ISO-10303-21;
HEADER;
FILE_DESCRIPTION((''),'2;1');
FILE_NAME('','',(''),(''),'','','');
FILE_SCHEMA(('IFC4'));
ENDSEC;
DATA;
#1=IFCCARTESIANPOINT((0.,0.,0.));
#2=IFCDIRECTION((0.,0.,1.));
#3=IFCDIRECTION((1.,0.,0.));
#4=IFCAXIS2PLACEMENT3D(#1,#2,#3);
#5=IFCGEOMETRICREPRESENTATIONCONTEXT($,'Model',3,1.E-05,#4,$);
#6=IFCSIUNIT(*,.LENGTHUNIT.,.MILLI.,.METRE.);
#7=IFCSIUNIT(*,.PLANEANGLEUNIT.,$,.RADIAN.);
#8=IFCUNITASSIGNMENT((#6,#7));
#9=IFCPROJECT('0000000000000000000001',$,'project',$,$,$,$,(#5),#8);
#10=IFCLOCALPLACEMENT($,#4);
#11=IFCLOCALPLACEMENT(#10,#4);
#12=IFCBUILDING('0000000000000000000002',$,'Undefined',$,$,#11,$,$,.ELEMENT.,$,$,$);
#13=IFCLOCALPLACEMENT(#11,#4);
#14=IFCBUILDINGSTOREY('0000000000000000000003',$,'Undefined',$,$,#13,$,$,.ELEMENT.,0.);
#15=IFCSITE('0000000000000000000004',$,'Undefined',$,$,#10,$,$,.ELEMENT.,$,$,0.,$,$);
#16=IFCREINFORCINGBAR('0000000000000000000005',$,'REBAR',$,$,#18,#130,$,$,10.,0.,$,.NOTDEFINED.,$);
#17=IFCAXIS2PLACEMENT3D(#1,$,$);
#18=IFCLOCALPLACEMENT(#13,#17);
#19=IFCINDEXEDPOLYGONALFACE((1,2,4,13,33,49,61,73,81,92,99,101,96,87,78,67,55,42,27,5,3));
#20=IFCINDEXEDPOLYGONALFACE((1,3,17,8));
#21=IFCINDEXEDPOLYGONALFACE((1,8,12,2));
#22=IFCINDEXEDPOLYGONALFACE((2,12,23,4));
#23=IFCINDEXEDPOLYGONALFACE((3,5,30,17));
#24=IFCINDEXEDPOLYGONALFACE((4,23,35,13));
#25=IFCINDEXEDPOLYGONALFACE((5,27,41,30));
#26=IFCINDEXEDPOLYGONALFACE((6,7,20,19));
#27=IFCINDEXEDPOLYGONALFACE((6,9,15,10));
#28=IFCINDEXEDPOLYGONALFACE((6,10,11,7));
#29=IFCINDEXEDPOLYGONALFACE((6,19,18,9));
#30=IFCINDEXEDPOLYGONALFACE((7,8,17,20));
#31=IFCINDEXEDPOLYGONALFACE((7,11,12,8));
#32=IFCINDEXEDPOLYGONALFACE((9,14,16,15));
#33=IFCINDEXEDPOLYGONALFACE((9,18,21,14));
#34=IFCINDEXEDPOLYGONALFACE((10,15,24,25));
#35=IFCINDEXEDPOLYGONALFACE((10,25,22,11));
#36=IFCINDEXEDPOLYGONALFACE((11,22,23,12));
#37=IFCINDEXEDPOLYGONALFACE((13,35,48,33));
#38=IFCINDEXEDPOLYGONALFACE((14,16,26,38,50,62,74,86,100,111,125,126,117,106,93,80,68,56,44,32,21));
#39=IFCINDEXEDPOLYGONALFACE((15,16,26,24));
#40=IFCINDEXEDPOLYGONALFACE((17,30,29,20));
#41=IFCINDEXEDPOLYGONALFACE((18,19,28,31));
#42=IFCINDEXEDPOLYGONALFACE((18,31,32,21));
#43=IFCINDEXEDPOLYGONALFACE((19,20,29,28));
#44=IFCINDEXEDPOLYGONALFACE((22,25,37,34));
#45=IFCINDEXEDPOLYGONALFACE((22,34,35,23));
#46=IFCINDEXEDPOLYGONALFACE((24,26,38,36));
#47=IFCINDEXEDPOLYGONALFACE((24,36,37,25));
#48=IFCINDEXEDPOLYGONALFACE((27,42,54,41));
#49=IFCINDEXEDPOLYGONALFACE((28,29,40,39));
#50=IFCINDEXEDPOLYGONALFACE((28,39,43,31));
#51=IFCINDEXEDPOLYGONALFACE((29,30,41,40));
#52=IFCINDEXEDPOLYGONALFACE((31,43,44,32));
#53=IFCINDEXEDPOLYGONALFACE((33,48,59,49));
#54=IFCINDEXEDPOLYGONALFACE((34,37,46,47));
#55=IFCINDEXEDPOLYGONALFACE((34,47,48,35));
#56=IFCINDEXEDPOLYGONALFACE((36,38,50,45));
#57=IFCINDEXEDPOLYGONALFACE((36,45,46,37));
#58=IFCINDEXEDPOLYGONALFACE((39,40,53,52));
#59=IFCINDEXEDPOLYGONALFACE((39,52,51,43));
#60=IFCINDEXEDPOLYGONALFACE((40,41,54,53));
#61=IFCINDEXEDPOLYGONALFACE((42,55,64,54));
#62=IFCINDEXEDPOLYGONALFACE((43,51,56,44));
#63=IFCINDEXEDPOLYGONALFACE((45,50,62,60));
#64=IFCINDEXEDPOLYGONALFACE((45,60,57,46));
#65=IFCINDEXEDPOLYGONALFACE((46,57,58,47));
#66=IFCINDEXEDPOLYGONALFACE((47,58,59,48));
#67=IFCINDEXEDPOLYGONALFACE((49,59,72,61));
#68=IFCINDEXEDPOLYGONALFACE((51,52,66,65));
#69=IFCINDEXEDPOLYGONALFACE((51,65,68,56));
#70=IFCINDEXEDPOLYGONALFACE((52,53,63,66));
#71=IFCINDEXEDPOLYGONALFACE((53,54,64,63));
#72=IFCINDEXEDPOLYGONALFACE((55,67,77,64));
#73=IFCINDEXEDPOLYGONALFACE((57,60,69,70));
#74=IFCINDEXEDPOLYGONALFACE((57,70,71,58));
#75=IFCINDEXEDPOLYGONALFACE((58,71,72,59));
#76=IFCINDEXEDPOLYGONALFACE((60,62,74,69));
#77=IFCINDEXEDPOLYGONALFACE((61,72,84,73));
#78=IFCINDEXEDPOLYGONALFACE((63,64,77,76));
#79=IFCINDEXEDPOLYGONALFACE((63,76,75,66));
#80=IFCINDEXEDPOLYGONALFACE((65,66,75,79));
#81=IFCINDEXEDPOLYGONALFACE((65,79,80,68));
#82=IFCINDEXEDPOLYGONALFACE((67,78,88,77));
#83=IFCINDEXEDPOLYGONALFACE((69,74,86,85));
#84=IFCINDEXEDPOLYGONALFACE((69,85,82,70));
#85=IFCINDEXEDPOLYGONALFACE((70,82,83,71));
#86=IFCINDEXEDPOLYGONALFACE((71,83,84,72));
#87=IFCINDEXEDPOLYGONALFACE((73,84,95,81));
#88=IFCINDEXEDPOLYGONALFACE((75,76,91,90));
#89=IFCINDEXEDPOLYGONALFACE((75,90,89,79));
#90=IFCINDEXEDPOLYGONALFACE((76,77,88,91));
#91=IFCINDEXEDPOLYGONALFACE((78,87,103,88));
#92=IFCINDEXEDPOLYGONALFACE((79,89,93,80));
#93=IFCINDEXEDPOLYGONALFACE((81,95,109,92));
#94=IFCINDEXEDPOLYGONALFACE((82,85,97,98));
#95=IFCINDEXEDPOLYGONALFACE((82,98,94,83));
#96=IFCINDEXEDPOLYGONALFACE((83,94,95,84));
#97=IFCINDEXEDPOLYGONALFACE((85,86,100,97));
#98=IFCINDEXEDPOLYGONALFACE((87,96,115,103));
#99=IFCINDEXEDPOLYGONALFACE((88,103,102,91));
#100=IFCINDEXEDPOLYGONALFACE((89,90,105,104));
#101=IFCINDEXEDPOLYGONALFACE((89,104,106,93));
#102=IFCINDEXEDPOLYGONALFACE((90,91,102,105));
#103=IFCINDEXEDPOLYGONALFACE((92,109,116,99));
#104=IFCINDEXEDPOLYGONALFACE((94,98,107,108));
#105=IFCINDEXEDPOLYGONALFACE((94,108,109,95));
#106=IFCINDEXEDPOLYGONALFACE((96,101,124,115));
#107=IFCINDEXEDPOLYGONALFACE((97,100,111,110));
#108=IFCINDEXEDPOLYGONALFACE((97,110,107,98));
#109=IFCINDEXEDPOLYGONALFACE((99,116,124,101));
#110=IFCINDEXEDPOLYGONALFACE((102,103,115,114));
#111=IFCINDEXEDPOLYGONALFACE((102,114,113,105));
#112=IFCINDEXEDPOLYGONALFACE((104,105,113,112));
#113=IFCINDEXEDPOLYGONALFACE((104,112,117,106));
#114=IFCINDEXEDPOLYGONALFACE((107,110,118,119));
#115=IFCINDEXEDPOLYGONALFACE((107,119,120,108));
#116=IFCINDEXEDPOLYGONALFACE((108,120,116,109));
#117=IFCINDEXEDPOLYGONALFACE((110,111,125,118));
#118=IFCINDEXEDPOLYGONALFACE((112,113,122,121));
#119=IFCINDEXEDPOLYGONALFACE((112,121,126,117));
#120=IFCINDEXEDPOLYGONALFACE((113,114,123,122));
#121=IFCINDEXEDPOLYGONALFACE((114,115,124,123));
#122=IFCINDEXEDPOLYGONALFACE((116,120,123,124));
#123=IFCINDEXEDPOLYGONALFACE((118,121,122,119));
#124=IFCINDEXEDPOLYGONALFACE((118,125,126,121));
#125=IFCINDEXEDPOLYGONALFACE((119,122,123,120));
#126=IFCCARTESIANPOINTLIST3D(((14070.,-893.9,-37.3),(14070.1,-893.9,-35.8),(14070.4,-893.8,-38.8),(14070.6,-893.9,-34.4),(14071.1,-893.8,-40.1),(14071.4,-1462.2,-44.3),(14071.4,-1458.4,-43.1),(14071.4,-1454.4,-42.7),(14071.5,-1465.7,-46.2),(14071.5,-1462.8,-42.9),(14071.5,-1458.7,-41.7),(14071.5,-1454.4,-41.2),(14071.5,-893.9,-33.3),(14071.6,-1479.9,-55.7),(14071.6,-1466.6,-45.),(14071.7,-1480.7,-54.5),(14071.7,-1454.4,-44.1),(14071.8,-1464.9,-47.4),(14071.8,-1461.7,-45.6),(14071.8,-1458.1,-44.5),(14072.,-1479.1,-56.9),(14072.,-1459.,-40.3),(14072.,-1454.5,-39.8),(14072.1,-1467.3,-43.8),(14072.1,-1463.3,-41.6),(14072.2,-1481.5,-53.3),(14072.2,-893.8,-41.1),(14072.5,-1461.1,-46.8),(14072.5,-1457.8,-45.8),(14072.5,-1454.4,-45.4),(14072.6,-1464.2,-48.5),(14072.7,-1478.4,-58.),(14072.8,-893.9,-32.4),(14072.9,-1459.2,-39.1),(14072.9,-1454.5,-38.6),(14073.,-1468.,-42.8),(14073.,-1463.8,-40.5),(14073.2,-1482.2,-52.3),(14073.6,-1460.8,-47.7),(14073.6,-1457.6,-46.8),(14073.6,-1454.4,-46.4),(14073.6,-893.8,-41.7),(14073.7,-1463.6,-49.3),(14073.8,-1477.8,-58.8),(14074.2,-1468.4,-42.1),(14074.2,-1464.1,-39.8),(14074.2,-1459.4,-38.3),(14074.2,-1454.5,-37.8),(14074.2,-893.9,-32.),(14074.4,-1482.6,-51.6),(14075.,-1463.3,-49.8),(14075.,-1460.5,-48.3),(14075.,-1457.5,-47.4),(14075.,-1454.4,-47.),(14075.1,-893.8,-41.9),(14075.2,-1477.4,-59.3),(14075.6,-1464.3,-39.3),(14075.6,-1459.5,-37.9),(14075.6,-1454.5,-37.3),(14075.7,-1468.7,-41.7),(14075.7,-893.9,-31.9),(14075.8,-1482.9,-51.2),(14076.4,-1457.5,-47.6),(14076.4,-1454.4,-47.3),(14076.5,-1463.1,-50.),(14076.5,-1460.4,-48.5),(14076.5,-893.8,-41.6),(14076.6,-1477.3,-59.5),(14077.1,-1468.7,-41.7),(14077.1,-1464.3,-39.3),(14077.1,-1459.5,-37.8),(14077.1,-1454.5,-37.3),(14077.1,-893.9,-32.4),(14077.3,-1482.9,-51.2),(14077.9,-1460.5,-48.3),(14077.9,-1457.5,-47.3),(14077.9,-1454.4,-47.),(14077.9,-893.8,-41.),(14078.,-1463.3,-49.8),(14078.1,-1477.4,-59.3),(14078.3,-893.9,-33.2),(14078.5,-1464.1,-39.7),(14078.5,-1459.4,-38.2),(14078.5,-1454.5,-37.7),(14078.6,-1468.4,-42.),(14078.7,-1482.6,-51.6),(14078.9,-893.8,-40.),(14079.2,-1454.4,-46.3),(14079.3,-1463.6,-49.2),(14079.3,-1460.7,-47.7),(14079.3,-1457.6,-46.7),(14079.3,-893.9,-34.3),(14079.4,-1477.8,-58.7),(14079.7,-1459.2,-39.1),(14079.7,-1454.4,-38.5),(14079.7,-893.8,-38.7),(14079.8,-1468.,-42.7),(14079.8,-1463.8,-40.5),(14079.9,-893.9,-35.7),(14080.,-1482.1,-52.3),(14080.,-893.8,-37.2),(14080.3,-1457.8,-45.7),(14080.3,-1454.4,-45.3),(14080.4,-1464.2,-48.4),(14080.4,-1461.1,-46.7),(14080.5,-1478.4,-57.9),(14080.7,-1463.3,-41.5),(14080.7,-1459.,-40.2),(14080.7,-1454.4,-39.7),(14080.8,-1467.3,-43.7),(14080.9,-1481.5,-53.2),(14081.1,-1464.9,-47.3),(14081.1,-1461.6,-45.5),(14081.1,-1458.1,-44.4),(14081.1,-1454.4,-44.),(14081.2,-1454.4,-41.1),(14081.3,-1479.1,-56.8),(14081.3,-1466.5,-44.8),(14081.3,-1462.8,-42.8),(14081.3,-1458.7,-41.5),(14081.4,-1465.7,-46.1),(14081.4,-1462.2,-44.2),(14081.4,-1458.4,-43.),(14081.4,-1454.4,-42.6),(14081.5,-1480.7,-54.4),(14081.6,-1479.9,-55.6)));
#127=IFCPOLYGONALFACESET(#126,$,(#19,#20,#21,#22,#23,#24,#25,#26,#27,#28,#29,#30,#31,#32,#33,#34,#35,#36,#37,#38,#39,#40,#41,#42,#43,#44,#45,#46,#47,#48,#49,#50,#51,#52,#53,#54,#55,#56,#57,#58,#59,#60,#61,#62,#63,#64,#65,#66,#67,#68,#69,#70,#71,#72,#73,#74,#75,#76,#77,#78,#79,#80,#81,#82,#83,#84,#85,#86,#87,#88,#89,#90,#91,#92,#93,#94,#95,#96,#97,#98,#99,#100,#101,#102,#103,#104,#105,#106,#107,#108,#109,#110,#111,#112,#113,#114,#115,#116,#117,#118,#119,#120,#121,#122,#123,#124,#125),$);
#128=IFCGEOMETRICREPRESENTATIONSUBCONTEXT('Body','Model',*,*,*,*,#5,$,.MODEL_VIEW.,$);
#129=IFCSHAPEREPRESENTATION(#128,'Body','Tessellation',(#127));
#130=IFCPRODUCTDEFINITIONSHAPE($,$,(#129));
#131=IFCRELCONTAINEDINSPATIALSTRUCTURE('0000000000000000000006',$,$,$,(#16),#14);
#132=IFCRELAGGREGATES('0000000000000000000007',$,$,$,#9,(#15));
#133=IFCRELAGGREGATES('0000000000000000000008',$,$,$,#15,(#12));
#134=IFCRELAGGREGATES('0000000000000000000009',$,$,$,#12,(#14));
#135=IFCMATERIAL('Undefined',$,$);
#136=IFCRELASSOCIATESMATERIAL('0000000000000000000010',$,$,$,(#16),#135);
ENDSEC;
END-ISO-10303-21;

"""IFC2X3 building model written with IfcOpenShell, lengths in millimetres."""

from ifc_helpers import new_model, entity, si_unit, frame, origin_with_axes, place, context, subcontext, project, spatial, source, transform, mapped, material, element, save


model = new_model("IFC2X3")

# Units and contexts
model_context = context("Model", 3, precision=1e-05, world=origin_with_axes())
body_context = subcontext(model_context, "Body", "Model", "MODEL_VIEW")
ifc_project = project(units=[si_unit("LENGTHUNIT", "METRE", prefix="MILLI"), si_unit("PLANEANGLEUNIT", "RADIAN")], contexts=[model_context])

# Site, building, storey
site_placement = place(None, origin_with_axes())
site = spatial("IfcSite", under=ifc_project, at=site_placement, Name="Undefined", CompositionType="ELEMENT", RefElevation=0.0)
building_placement = place(site_placement, origin_with_axes())
building = spatial("IfcBuilding", under=site, at=building_placement, Name="Undefined", CompositionType="ELEMENT")
storey_placement = place(building_placement, origin_with_axes())
storey = spatial("IfcBuildingStorey", under=building, at=storey_placement, Name="Undefined", CompositionType="ELEMENT", Elevation=0.0)

# Reinforcing bar
ifc_material_1 = material(Name="Undefined")
shared_shape_1 = source(origin_with_axes(), body_context, "Body", "AdvancedSweptSolid", [
    entity("IfcSweptDiskSolid", entity("IfcCompositeCurve", [entity("IfcCompositeCurveSegment", "CONTINUOUS", True, entity("IfcTrimmedCurve", entity("IfcLine", entity("IfcCartesianPoint", [0.0, 0.0, 0.0]), entity("IfcVector", entity("IfcDirection", [0.835483, 0.0, -0.549516]), 1.0)), [entity("IfcParameterValue", 0.0)], [entity("IfcParameterValue", 17.082101)], True, "PARAMETER")), entity("IfcCompositeCurveSegment", "CONTINUOUS", True, entity("IfcTrimmedCurve", entity("IfcCircle", entity("IfcAxis2Placement3D", entity("IfcCartesianPoint", [25.8, 0.0, 8.2]), entity("IfcDirection", [0.0, -1.0, 0.0]), entity("IfcDirection", [-0.549516, 0.0, -0.835483])), 21.0), [entity("IfcParameterValue", 0.0)], [entity("IfcParameterValue", 0.581785)], True, "PARAMETER")), entity("IfcCompositeCurveSegment", "DISCONTINUOUS", True, entity("IfcTrimmedCurve", entity("IfcLine", entity("IfcCartesianPoint", [25.8, 0.0, -12.8]), entity("IfcVector", entity("IfcDirection", [1.0, 0.0, 0.0]), 1.0)), [entity("IfcParameterValue", 0.0)], [entity("IfcParameterValue", 560.593055)], True, "PARAMETER"))], False), 5.0, None, 0.0, 578.3),
])
reinforcing_bar_1_placement = place(storey_placement, frame((14076.4, -1471.5, -44.9), z_axis=(0.012204, 0.009592, -0.99988), x_axis=(-0.002468, 0.999951, 0.009562)))
element("IfcReinforcingBar", 1, at=reinforcing_bar_1_placement, inside=storey, material=ifc_material_1, Name="REBAR", BarRole="NOTDEFINED", CrossSectionArea=0.0, NominalDiameter=10.0, context=body_context, shape_type="MappedRepresentation", body=[
    mapped(shared_shape_1, transform((-8.7, 0.0, 10.3))),
])

save(model, "model.ifc")
